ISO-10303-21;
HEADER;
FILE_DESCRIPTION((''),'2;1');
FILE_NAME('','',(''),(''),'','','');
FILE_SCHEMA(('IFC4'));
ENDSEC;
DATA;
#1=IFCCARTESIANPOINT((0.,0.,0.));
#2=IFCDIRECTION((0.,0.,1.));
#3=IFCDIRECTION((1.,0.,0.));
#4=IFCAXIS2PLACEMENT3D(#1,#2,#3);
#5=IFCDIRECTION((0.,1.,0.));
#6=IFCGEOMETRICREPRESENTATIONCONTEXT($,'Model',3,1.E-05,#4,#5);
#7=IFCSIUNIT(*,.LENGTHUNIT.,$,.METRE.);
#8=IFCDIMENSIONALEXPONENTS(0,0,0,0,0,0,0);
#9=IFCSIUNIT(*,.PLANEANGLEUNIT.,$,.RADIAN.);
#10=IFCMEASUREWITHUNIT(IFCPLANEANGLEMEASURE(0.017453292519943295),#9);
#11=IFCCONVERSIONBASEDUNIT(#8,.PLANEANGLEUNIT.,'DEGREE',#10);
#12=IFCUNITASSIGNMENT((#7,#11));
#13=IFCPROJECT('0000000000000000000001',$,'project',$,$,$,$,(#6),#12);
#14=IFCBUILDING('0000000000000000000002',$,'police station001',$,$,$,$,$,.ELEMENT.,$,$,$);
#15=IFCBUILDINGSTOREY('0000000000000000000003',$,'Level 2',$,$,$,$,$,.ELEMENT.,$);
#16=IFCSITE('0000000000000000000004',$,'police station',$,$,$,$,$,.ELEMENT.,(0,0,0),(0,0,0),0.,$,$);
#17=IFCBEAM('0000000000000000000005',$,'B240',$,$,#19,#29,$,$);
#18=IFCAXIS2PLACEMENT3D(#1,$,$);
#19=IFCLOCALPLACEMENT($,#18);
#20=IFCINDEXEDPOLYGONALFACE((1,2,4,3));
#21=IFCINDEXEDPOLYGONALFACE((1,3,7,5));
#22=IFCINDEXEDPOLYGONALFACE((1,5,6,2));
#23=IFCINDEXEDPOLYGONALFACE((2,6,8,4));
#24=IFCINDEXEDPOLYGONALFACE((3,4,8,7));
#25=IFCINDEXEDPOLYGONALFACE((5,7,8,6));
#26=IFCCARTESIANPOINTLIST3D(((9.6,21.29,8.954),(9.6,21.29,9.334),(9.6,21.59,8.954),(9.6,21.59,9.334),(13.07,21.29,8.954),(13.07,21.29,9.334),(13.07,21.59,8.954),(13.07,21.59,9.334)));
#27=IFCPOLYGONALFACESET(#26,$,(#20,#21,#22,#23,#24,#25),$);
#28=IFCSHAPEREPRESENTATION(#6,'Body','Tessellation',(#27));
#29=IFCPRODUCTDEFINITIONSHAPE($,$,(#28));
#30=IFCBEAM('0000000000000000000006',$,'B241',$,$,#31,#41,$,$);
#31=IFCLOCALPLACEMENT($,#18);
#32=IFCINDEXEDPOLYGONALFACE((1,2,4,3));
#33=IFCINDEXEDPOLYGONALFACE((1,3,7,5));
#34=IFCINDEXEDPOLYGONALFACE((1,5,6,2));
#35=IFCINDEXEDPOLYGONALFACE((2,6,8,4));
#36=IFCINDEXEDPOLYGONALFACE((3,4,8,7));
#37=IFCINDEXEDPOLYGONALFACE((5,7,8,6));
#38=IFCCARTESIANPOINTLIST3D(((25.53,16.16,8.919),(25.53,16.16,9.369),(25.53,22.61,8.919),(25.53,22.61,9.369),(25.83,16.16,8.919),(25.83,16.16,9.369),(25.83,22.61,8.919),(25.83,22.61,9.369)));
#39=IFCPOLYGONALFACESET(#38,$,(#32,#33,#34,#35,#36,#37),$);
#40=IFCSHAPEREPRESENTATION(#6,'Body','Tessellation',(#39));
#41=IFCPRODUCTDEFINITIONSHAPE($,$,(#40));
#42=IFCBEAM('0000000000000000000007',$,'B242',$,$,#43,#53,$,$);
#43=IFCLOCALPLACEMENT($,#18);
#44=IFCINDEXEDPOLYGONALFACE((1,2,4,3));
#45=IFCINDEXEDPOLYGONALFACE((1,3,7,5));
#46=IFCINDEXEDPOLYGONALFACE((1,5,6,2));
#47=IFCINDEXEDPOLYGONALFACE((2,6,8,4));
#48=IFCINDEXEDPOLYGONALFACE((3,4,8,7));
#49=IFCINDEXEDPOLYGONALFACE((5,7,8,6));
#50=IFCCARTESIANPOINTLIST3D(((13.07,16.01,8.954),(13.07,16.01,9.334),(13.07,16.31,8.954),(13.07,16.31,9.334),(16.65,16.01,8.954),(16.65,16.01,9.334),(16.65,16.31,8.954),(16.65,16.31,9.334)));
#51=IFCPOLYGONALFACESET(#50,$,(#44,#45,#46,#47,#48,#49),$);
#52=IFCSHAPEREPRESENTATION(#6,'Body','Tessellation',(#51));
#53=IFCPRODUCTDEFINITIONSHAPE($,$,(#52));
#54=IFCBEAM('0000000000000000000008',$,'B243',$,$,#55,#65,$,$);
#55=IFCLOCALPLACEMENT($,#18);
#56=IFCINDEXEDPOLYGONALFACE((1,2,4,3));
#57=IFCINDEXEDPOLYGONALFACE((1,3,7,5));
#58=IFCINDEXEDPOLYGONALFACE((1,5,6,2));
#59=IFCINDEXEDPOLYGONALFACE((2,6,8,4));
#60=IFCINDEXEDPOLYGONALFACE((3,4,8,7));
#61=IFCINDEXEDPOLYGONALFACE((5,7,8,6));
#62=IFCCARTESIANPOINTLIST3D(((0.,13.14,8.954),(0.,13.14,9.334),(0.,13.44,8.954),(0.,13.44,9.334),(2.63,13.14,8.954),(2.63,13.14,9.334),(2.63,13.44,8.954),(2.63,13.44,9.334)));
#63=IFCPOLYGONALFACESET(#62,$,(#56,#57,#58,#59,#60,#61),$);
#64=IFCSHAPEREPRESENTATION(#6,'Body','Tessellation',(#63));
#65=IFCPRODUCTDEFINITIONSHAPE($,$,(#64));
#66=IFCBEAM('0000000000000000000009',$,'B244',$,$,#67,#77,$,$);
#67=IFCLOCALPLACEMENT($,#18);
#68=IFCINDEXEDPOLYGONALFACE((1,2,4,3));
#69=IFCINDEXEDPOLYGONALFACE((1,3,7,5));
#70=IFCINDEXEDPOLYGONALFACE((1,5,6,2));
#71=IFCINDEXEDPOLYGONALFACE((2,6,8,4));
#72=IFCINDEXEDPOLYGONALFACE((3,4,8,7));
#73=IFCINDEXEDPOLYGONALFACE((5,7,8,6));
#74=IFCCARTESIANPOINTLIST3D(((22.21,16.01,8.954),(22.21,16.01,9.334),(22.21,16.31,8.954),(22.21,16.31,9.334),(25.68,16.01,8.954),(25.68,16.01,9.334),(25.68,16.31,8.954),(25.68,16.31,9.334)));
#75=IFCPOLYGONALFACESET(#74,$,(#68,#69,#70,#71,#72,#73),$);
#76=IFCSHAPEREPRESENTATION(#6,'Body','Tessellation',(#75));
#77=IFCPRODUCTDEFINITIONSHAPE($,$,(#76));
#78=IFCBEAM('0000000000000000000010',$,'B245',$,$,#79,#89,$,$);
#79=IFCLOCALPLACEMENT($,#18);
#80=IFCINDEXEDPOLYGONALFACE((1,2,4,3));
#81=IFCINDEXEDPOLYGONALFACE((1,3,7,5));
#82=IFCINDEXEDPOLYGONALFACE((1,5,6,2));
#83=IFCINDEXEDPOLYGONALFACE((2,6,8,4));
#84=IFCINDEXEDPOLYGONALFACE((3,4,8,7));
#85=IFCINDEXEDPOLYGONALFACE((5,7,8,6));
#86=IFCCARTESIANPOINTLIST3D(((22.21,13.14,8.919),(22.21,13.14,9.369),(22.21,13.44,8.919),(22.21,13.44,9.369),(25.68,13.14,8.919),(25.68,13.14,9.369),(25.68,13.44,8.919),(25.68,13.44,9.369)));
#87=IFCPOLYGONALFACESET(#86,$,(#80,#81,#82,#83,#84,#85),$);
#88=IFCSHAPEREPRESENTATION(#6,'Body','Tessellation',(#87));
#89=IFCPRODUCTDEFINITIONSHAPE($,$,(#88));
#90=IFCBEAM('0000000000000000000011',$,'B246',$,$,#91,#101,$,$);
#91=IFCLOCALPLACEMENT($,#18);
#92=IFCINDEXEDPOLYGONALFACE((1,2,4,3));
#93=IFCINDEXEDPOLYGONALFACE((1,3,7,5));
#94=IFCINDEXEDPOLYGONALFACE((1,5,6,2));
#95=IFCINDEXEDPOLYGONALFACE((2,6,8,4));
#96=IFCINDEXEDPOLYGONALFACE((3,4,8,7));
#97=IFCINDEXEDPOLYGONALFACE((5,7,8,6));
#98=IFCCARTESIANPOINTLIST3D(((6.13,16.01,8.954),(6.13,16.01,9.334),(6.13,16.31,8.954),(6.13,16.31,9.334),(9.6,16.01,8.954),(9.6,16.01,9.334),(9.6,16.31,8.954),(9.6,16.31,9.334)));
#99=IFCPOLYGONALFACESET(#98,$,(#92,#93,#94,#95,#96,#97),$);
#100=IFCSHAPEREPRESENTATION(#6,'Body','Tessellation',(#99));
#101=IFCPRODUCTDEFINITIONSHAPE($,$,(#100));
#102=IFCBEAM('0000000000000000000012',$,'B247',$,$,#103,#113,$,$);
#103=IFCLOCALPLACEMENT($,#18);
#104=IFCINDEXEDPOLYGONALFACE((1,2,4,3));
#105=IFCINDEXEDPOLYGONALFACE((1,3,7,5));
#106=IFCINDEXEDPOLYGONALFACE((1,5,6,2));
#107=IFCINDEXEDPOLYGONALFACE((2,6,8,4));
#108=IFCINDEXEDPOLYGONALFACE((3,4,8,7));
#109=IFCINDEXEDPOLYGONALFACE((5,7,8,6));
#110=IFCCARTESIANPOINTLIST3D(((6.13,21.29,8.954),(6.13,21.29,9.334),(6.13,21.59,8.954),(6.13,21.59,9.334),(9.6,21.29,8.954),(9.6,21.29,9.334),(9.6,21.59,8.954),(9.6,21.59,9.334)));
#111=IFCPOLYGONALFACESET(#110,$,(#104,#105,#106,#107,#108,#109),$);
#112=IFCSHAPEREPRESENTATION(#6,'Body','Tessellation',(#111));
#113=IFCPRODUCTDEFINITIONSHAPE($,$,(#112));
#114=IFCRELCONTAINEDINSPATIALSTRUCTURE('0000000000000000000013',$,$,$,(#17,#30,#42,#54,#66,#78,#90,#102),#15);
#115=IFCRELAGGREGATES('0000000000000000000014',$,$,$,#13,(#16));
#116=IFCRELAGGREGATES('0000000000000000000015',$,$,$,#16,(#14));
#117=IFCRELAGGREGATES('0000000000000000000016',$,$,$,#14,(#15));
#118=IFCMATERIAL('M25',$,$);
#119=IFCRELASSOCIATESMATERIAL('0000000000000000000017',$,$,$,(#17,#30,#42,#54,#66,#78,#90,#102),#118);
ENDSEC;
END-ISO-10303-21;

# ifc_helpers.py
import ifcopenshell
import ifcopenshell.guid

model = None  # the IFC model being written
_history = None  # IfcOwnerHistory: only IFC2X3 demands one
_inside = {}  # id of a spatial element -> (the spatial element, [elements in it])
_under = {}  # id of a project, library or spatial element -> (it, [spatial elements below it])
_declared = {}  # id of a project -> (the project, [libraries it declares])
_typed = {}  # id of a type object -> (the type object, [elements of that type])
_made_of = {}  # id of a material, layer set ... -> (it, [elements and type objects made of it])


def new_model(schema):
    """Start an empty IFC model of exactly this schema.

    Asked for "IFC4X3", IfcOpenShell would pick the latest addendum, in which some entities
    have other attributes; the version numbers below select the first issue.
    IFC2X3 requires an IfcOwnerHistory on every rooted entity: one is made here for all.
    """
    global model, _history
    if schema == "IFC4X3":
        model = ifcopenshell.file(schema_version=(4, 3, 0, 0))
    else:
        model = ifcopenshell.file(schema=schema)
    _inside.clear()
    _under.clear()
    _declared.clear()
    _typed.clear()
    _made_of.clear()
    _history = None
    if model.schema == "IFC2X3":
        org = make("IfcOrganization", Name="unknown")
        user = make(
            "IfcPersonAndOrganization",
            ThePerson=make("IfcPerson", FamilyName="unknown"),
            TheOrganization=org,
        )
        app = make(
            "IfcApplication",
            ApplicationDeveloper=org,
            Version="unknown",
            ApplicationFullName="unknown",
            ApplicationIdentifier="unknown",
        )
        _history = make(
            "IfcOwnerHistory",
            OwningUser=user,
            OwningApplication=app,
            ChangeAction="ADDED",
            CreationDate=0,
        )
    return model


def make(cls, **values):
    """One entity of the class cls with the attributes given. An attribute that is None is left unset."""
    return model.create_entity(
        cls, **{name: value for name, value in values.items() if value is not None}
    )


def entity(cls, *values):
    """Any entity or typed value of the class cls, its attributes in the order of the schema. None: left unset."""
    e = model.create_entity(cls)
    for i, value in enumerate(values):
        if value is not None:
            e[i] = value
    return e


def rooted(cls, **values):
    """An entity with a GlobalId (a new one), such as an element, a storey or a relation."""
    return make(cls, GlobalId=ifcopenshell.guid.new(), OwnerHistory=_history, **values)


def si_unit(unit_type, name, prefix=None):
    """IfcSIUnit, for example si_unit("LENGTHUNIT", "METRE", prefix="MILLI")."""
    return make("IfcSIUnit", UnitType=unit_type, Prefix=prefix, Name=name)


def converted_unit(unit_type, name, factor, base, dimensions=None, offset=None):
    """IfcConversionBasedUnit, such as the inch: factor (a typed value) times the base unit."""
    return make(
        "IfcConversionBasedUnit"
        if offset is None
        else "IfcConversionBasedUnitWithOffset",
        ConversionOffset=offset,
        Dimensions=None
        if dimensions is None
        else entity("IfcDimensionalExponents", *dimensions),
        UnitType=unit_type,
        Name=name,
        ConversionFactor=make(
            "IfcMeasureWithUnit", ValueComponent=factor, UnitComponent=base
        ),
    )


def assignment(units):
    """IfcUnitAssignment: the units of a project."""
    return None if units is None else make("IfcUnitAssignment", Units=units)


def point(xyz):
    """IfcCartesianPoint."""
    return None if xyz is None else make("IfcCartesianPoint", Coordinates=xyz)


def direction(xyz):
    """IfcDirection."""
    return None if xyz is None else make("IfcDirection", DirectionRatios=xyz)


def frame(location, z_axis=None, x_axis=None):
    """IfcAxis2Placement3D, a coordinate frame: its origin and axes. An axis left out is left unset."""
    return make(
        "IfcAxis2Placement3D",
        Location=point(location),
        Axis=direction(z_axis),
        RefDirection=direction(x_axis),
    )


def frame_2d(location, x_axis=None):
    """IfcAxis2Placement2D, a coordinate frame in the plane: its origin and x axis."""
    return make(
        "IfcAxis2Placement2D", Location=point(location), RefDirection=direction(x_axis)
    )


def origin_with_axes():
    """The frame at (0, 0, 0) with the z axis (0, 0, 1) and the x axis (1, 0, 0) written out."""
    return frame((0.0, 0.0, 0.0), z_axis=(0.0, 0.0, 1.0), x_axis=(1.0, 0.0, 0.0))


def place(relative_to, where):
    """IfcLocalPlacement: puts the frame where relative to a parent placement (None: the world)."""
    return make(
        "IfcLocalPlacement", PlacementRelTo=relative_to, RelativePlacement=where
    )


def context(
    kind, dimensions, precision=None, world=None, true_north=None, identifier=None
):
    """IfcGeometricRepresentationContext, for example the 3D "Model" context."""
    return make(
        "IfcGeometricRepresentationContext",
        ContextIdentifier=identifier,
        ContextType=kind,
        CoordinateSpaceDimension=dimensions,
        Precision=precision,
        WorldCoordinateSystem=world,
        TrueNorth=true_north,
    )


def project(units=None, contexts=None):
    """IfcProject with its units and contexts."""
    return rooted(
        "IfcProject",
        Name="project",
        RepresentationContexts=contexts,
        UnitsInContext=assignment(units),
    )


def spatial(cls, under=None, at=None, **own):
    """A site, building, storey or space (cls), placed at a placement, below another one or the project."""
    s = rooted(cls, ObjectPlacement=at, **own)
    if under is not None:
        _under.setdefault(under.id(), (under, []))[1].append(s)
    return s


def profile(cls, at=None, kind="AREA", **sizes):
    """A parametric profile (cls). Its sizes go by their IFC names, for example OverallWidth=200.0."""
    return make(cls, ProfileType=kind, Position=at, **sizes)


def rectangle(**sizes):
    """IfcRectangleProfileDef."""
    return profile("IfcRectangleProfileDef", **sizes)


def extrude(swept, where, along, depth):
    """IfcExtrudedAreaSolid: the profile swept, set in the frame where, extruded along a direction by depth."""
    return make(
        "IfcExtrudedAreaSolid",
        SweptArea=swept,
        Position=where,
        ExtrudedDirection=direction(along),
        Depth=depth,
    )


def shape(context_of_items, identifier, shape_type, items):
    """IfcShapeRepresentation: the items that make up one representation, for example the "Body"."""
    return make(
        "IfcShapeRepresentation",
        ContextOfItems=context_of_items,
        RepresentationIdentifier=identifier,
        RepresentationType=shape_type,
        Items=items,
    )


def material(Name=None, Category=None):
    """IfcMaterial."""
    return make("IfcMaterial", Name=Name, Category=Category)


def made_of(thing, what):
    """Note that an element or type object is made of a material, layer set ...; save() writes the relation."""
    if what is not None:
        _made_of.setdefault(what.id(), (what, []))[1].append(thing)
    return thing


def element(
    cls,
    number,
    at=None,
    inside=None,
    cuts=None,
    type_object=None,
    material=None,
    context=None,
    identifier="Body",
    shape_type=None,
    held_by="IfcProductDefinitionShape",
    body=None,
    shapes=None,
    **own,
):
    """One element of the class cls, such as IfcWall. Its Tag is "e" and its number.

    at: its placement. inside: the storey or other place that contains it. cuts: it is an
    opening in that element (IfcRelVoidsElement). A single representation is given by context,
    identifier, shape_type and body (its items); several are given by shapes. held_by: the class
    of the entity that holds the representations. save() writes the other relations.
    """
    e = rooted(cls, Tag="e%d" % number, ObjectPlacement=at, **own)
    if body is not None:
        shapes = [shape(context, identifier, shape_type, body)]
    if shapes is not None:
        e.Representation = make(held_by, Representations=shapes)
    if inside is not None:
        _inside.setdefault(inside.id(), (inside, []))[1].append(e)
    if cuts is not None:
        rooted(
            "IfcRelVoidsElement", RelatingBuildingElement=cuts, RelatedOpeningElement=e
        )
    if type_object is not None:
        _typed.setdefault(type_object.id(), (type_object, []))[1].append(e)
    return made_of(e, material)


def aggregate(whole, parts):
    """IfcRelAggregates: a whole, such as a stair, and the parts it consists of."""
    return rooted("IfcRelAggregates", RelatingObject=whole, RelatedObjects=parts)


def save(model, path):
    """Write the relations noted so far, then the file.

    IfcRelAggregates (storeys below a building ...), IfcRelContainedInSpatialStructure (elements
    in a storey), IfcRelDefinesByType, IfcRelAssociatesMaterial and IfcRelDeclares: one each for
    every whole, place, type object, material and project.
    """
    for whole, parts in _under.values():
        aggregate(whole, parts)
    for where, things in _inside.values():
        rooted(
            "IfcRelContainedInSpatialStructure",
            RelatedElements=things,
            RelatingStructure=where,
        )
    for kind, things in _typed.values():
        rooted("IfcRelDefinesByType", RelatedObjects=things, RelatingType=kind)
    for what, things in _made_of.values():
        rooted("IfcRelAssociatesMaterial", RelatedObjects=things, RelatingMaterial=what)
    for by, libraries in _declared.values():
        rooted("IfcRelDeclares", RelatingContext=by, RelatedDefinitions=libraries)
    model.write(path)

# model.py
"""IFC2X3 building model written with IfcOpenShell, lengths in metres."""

from ifc_helpers import new_model, entity, si_unit, converted_unit, direction, frame, frame_2d, origin_with_axes, place, context, project, spatial, rectangle, extrude, material, element, save


model = new_model("IFC2X3")

# Units and contexts
model_context = context("Model", 3, precision=1e-05, world=origin_with_axes(), true_north=direction((0.0, 1.0, 0.0)))
ifc_project = project(units=[si_unit("LENGTHUNIT", "METRE"), converted_unit("PLANEANGLEUNIT", "DEGREE", entity("IfcPlaneAngleMeasure", 0.017453292519943295), si_unit("PLANEANGLEUNIT", "RADIAN"), dimensions=[0, 0, 0, 0, 0, 0, 0])], contexts=[model_context])

# Site, building, storey
site = spatial("IfcSite", under=ifc_project, Name="police station", CompositionType="ELEMENT", RefLatitude=(0, 0, 0), RefLongitude=(0, 0, 0), RefElevation=0.0)
building = spatial("IfcBuilding", under=site, Name="police station001", CompositionType="ELEMENT")
storey = spatial("IfcBuildingStorey", under=building, Name="Level 2", CompositionType="ELEMENT")

# Beams
ifc_material = material(Name="M25")
placement = place(None, origin_with_axes())
element("IfcBeam", 1, at=placement, inside=storey, material=ifc_material, Name="B240", context=model_context, shape_type="SweptSolid", body=[
    extrude(rectangle(XDim=0.3, YDim=0.38, at=frame_2d((0.0, 0.0), x_axis=(0.0, 1.0, 0.0))), frame((13.07, 21.44, 9.144), z_axis=(-1.0, 0.0, 0.0), x_axis=(0.0, 0.0, -1.0)), (0.0, 0.0, 1.0), 3.47),
])
element("IfcBeam", 2, at=placement, inside=storey, material=ifc_material, Name="B241", context=model_context, shape_type="SweptSolid", body=[
    extrude(rectangle(XDim=0.3, YDim=0.45, at=frame_2d((0.0, 0.0), x_axis=(0.0, 1.0, 0.0))), frame((25.68, 22.61, 9.144), z_axis=(0.0, -1.0, 0.0), x_axis=(0.0, 0.0, -1.0)), (0.0, 0.0, 1.0), 6.45),
])
element("IfcBeam", 3, at=placement, inside=storey, material=ifc_material, Name="B242", context=model_context, shape_type="SweptSolid", body=[
    extrude(rectangle(XDim=0.3, YDim=0.38, at=frame_2d((0.0, 0.0), x_axis=(0.0, 1.0, 0.0))), frame((16.65, 16.16, 9.144), z_axis=(-1.0, 0.0, 0.0), x_axis=(0.0, 0.0, -1.0)), (0.0, 0.0, 1.0), 3.58),
])
element("IfcBeam", 4, at=placement, inside=storey, material=ifc_material, Name="B243", context=model_context, shape_type="SweptSolid", body=[
    extrude(rectangle(XDim=0.3, YDim=0.38, at=frame_2d((0.0, 0.0), x_axis=(0.0, 1.0, 0.0))), frame((0.0, 13.29, 9.144), z_axis=(1.0, 0.0, 0.0), x_axis=(0.0, 0.0, -1.0)), (0.0, 0.0, 1.0), 2.63),
])
element("IfcBeam", 5, at=placement, inside=storey, material=ifc_material, Name="B244", context=model_context, shape_type="SweptSolid", body=[
    extrude(rectangle(XDim=0.3, YDim=0.38, at=frame_2d((0.0, 0.0), x_axis=(0.0, 1.0, 0.0))), frame((22.21, 16.16, 9.144), z_axis=(1.0, 0.0, 0.0), x_axis=(0.0, 0.0, -1.0)), (0.0, 0.0, 1.0), 3.47),
])
element("IfcBeam", 6, at=placement, inside=storey, material=ifc_material, Name="B245", context=model_context, shape_type="SweptSolid", body=[
    extrude(rectangle(XDim=0.3, YDim=0.45, at=frame_2d((0.0, 0.0), x_axis=(0.0, 1.0, 0.0))), frame((25.68, 13.29, 9.144), z_axis=(-1.0, 0.0, 0.0), x_axis=(0.0, 0.0, -1.0)), (0.0, 0.0, 1.0), 3.47),
])
element("IfcBeam", 7, at=placement, inside=storey, material=ifc_material, Name="B246", context=model_context, shape_type="SweptSolid", body=[
    extrude(rectangle(XDim=0.3, YDim=0.38, at=frame_2d((0.0, 0.0), x_axis=(0.0, 1.0, 0.0))), frame((9.6, 16.16, 9.144), z_axis=(-1.0, 0.0, 0.0), x_axis=(0.0, 0.0, -1.0)), (0.0, 0.0, 1.0), 3.47),
])
element("IfcBeam", 8, at=placement, inside=storey, material=ifc_material, Name="B247", context=model_context, shape_type="SweptSolid", body=[
    extrude(rectangle(XDim=0.3, YDim=0.38, at=frame_2d((0.0, 0.0), x_axis=(0.0, 1.0, 0.0))), frame((9.6, 21.44, 9.144), z_axis=(-1.0, 0.0, 0.0), x_axis=(0.0, 0.0, -1.0)), (0.0, 0.0, 1.0), 3.47),
])

save(model, "model.ifc")
